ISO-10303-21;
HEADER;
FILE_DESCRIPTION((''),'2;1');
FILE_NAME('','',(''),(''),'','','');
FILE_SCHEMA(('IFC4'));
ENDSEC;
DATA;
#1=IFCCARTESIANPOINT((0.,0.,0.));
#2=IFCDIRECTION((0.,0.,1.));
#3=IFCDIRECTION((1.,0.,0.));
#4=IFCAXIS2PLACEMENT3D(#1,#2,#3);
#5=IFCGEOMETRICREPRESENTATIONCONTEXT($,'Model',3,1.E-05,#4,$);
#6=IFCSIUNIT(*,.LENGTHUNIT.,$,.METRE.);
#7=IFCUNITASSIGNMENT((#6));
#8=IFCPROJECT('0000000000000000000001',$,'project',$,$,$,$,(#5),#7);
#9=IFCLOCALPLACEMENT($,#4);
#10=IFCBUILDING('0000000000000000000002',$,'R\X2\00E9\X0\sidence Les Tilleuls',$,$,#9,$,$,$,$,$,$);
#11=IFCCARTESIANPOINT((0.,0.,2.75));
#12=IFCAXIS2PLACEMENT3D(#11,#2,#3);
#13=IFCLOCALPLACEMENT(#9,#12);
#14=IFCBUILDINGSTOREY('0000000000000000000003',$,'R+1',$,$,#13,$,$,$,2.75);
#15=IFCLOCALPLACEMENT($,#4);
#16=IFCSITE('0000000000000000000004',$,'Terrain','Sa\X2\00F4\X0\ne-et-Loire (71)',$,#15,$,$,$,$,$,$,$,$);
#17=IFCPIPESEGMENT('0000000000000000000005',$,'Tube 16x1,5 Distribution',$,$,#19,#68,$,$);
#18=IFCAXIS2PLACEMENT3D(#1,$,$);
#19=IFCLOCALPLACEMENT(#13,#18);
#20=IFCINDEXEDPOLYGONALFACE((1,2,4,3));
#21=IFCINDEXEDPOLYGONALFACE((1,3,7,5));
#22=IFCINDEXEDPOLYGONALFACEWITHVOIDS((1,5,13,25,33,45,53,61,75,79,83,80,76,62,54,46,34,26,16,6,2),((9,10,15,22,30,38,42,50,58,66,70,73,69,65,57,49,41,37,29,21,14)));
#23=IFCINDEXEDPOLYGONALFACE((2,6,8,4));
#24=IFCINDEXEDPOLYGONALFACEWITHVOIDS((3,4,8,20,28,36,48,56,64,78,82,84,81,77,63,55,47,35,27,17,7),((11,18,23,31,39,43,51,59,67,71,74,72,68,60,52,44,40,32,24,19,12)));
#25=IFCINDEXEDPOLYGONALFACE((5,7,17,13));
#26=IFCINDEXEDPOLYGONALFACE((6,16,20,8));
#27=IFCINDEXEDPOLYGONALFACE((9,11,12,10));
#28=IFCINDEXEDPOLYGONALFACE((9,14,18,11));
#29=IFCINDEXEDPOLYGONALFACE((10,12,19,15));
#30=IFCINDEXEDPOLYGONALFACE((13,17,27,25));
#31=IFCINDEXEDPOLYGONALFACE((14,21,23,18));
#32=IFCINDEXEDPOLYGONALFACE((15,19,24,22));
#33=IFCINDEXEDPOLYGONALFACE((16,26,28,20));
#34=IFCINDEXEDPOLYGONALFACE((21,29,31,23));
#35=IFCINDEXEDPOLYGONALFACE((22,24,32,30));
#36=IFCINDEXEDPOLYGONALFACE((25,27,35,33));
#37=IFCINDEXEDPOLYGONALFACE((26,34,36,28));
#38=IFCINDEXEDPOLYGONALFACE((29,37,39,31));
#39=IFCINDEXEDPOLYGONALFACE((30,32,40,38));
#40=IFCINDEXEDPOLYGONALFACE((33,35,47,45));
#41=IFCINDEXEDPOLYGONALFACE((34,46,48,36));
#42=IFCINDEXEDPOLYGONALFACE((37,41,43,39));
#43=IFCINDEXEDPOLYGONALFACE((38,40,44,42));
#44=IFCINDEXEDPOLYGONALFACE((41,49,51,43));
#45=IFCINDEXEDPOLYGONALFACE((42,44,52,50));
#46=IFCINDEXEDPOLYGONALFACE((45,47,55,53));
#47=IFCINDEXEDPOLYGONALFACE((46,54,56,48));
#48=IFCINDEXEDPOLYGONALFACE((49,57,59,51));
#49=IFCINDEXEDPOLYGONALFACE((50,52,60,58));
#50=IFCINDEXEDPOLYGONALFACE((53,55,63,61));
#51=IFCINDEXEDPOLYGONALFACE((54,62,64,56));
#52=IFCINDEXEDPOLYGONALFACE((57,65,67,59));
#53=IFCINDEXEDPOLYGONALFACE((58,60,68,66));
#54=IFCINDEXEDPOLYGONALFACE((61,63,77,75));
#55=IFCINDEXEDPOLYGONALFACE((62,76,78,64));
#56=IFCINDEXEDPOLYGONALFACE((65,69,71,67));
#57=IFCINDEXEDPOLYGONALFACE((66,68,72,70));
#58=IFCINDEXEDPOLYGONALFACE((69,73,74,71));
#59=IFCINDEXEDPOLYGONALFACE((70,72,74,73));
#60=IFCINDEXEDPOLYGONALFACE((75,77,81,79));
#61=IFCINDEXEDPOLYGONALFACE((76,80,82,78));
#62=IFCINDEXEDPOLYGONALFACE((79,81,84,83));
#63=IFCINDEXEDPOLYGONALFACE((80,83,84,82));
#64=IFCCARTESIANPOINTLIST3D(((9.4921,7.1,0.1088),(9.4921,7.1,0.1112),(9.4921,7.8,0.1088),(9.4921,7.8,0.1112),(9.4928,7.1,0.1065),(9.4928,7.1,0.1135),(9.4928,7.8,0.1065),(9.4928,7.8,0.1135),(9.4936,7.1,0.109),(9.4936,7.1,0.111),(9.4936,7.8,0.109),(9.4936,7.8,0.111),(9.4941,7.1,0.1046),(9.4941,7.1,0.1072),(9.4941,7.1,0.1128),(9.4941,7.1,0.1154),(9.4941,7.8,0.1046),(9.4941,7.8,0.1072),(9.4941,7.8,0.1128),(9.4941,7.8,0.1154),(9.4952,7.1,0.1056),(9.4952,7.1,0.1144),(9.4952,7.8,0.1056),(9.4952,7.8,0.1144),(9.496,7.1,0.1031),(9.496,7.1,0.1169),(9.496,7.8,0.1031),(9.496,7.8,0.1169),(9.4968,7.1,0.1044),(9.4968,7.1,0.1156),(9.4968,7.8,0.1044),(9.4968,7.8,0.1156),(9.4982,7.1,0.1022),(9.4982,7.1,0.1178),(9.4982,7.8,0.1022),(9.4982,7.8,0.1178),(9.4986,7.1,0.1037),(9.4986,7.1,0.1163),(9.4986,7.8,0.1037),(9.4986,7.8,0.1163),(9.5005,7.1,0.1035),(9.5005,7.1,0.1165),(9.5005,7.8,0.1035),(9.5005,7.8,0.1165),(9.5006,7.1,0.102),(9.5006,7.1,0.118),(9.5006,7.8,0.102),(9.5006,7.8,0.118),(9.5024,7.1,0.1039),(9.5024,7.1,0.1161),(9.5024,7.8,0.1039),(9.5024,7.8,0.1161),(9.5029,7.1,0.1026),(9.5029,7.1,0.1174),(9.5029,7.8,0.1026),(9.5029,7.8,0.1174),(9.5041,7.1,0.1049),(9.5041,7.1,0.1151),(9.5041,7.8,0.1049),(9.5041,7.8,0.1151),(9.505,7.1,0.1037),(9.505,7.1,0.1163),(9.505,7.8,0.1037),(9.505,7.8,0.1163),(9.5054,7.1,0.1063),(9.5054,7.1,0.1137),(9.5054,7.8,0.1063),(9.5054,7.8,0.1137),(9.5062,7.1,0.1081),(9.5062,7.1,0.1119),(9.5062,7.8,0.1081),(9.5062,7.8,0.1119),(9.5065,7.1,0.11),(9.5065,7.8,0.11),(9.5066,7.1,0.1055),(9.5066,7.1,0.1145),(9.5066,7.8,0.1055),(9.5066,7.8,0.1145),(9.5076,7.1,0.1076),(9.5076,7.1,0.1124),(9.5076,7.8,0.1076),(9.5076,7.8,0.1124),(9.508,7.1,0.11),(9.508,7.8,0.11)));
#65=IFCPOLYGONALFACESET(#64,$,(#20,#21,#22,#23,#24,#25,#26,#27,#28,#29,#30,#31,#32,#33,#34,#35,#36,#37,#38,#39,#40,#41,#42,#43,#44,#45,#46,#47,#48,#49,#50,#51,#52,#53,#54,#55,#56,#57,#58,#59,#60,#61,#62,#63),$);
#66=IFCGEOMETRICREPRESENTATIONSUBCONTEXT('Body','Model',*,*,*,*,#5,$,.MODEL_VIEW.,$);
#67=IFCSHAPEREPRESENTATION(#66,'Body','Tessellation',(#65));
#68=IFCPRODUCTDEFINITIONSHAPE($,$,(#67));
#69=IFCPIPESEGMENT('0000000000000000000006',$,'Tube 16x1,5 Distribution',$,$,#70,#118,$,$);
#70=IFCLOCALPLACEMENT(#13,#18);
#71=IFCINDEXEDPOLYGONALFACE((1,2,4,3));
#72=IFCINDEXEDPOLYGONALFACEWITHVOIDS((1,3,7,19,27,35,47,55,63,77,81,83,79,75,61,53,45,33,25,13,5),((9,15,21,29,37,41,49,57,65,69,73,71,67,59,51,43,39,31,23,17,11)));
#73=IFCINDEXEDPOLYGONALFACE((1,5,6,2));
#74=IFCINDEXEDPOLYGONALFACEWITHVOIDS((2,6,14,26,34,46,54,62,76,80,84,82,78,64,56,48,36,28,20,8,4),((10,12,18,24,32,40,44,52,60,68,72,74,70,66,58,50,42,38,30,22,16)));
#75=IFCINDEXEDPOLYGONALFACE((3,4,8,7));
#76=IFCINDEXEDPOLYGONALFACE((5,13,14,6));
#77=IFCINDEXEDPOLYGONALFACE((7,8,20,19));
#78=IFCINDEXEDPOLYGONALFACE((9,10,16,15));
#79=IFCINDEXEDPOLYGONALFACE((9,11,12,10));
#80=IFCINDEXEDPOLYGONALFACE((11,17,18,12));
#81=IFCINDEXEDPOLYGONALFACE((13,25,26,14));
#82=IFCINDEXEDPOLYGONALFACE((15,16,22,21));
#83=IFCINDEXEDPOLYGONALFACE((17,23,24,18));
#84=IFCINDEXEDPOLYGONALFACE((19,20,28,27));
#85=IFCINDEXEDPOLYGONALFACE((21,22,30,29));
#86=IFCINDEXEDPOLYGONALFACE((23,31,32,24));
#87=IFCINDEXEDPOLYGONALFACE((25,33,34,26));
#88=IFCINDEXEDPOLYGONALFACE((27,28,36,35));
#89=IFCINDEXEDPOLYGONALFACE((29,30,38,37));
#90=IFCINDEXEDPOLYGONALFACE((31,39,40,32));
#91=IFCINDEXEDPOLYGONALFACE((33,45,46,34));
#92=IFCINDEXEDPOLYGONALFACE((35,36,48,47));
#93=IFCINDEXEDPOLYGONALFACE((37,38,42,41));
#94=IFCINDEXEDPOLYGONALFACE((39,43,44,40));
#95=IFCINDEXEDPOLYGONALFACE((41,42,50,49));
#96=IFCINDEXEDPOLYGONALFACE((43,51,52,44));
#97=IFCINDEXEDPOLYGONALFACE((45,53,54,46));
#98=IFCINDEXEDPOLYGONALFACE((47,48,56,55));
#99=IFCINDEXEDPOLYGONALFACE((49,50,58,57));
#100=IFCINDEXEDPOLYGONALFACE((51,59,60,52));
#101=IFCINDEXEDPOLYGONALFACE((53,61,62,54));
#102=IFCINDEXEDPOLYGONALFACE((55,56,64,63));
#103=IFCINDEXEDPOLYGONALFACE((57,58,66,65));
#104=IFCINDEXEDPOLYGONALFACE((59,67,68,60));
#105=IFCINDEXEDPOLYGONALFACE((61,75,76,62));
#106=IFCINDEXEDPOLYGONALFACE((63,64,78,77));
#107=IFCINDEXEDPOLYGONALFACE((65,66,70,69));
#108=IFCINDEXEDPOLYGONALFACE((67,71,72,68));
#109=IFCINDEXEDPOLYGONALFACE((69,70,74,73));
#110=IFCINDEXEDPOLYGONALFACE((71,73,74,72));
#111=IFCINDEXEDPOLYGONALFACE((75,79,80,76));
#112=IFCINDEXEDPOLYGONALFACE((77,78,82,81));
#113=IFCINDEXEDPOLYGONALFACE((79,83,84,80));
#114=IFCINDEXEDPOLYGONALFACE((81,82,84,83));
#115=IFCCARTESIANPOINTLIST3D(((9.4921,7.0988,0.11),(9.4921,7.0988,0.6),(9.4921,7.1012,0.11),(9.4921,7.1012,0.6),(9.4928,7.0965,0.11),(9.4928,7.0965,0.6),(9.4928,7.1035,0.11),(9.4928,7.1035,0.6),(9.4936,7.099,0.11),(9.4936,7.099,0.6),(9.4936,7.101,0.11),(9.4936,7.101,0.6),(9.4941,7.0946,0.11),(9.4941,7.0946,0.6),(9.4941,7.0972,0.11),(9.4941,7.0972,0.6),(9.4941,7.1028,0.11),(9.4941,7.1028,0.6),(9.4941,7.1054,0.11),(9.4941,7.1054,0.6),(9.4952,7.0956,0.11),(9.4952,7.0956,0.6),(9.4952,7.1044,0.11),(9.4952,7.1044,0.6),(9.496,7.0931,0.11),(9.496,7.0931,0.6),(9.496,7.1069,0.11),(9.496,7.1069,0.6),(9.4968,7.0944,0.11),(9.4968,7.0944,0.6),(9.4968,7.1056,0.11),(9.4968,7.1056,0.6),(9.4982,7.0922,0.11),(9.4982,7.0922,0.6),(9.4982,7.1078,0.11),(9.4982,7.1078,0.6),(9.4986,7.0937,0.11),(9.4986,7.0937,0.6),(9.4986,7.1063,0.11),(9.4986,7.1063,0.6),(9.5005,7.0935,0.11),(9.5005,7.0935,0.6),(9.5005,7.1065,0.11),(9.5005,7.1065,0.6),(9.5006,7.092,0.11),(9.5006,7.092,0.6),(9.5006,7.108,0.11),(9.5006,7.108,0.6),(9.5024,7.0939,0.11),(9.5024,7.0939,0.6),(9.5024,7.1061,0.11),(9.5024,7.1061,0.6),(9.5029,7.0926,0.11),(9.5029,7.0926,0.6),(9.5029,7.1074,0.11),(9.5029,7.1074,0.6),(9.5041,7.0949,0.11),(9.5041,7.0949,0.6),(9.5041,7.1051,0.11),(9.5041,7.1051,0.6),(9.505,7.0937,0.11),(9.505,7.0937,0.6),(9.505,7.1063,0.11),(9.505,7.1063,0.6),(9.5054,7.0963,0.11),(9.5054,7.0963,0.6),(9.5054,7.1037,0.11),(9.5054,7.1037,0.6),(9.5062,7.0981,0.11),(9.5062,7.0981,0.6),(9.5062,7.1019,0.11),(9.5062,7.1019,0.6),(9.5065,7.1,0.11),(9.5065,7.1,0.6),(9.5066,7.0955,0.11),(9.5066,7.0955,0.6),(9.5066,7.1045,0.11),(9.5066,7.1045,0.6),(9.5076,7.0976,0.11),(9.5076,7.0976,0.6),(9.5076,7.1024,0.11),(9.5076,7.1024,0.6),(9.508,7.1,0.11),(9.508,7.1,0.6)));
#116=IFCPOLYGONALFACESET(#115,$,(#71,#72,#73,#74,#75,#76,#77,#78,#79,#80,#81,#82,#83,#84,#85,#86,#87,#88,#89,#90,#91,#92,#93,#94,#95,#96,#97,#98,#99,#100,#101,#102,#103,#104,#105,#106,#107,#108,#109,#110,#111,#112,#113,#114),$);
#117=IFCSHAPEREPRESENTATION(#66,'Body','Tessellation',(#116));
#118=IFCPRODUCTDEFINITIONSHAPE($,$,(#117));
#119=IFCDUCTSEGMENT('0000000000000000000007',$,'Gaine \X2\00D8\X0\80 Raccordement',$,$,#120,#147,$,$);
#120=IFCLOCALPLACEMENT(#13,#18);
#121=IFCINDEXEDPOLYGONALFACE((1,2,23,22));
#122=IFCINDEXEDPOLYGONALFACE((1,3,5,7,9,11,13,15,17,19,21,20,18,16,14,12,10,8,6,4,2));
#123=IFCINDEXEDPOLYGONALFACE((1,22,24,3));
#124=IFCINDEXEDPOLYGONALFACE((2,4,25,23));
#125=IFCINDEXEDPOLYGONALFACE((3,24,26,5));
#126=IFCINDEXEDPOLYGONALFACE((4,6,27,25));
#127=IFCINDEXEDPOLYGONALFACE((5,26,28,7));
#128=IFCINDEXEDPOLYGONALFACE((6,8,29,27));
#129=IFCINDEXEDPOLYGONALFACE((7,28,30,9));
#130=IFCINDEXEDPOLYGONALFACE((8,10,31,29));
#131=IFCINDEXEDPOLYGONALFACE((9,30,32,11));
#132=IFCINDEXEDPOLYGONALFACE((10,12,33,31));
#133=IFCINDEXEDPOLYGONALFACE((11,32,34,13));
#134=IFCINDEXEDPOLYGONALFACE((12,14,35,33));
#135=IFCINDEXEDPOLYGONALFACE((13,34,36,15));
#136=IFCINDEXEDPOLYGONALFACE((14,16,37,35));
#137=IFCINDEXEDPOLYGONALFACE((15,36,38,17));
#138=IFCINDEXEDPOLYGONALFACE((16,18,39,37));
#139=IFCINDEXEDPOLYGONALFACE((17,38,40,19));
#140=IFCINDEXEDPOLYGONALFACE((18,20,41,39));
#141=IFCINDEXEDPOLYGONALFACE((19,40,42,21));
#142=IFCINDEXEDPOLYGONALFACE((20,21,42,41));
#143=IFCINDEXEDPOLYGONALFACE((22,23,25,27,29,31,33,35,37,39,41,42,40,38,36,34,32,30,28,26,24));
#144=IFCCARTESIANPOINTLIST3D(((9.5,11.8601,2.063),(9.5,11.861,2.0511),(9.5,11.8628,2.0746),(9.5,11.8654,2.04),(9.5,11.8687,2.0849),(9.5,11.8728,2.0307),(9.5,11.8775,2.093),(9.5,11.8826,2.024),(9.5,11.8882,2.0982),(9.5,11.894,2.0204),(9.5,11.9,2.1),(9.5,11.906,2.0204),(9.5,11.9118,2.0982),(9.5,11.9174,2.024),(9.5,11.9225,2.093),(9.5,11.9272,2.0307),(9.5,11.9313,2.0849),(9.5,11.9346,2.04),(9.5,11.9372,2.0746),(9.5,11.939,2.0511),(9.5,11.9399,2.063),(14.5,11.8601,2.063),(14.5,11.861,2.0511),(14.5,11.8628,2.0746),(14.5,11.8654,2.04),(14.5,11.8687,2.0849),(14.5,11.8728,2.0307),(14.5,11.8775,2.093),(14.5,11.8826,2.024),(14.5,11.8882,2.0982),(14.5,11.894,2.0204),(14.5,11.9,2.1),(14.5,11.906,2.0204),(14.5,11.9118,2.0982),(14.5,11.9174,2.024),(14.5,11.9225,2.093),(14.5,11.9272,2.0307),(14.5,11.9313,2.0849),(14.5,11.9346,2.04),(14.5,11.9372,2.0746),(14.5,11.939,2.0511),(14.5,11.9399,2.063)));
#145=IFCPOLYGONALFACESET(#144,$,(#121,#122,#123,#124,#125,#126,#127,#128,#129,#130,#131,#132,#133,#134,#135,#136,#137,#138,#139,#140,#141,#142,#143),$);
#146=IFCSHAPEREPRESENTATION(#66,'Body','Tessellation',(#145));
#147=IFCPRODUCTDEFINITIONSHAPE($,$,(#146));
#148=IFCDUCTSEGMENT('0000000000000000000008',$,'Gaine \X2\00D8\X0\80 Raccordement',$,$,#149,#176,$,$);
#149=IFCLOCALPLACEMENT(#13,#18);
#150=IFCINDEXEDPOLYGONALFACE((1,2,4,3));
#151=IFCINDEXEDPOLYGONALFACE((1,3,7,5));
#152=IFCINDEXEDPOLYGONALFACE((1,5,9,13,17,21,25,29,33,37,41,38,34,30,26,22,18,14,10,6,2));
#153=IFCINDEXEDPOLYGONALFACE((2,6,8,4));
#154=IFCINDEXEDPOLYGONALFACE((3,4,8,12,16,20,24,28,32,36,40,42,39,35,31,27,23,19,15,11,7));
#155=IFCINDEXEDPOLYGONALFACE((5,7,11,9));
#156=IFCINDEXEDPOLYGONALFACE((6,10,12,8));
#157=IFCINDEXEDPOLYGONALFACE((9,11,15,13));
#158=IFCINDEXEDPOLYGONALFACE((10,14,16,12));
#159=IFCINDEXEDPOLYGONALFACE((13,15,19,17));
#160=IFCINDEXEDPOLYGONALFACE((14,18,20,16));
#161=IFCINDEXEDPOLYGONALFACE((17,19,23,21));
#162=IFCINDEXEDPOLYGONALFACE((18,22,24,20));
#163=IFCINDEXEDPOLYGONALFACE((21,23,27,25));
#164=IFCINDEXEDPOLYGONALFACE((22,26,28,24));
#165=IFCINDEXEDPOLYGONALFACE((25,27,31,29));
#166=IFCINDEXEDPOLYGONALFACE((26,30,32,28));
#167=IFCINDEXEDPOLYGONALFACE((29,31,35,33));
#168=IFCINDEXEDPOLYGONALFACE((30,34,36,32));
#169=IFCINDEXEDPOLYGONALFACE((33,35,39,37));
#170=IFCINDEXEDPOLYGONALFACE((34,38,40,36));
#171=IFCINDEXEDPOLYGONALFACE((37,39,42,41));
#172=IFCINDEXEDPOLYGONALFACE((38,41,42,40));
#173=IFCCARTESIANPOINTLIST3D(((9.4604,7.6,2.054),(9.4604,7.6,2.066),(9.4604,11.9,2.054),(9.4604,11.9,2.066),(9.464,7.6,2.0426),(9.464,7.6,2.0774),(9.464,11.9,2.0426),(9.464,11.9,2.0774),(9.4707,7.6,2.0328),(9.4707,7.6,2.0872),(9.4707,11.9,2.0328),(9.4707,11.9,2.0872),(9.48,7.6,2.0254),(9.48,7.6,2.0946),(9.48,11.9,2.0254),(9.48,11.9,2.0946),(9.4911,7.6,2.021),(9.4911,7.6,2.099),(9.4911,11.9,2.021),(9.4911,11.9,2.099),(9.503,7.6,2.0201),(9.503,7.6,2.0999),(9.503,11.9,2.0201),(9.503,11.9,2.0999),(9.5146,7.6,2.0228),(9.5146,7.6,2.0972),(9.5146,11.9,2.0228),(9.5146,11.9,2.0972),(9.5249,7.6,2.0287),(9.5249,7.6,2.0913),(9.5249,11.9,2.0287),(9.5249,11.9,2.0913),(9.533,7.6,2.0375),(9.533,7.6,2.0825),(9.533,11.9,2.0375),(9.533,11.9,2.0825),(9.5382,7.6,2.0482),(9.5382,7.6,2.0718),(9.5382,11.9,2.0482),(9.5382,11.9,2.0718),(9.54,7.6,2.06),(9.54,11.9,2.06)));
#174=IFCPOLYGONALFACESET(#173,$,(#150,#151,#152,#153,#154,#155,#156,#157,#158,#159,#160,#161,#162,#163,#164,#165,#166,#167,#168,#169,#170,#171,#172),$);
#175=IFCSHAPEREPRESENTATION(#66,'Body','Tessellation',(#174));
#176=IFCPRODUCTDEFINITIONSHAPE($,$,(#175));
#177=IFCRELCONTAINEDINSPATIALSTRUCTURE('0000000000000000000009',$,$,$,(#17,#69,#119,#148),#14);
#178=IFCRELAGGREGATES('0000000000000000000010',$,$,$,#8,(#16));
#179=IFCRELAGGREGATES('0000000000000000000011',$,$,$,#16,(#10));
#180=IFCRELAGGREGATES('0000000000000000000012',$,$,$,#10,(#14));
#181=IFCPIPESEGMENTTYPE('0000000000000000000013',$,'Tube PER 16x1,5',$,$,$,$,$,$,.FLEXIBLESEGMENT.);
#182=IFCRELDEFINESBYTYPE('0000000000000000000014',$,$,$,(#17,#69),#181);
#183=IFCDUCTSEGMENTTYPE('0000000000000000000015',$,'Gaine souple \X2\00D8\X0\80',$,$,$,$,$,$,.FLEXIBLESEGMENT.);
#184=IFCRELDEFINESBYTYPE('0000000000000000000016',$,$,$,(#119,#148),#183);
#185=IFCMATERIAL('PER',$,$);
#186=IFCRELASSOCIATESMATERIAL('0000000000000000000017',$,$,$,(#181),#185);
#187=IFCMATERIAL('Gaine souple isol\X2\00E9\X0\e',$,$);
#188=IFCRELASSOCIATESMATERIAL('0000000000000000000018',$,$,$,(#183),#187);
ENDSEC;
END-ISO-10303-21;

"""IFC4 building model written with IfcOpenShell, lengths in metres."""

from ifc_helpers import new_model, si_unit, frame, origin_with_axes, place, context, subcontext, project, spatial, circle, hollow_circle, extrude, material, type_object, element, save


model = new_model("IFC4")

# Units and contexts
model_context = context("Model", 3, precision=1e-05, world=origin_with_axes())
body_context = subcontext(model_context, "Body", "Model", "MODEL_VIEW")
ifc_project = project(units=[si_unit("LENGTHUNIT", "METRE")], contexts=[model_context])

# Site, building, storey
site_placement = place(None, origin_with_axes())
site = spatial("IfcSite", under=ifc_project, at=site_placement, Name="Terrain", Description="Saône-et-Loire (71)")
building_placement = place(None, origin_with_axes())
building = spatial("IfcBuilding", under=site, at=building_placement, Name="Résidence Les Tilleuls")
storey_placement = place(building_placement, frame((0.0, 0.0, 2.75), z_axis=(0.0, 0.0, 1.0), x_axis=(1.0, 0.0, 0.0)))
storey = spatial("IfcBuildingStorey", under=building, at=storey_placement, Name="R+1", Elevation=2.75)

# Pipe segments
ifc_material_1 = material(Name="PER")
pipe_segment_type_1 = type_object("IfcPipeSegmentType", Name="Tube PER 16x1,5", PredefinedType="FLEXIBLESEGMENT", material=ifc_material_1)
pipe_segment_1_placement = place(storey_placement, frame((9.5, 7.8, 0.11), z_axis=(0.0, -1.0, 0.0), x_axis=(1.0, 0.0, 0.0)))
element("IfcPipeSegment", 1, at=pipe_segment_1_placement, inside=storey, type_object=pipe_segment_type_1, Name="Tube 16x1,5 Distribution", context=body_context, shape_type="SweptSolid", body=[
    extrude(hollow_circle(Radius=0.008, WallThickness=0.0015), origin_with_axes(), (0.0, 0.0, 1.0), 0.7),
])
pipe_segment_2_placement = place(storey_placement, frame((9.5, 7.1, 0.11), z_axis=(0.0, 0.0, 1.0), x_axis=(1.0, 0.0, 0.0)))
element("IfcPipeSegment", 2, at=pipe_segment_2_placement, inside=storey, type_object=pipe_segment_type_1, Name="Tube 16x1,5 Distribution", context=body_context, shape_type="SweptSolid", body=[
    extrude(hollow_circle(Radius=0.008, WallThickness=0.0015), origin_with_axes(), (0.0, 0.0, 1.0), 0.49),
])

# Duct segments
ifc_material_2 = material(Name="Gaine souple isolée")
duct_segment_type = type_object("IfcDuctSegmentType", Name="Gaine souple Ø80", PredefinedType="FLEXIBLESEGMENT", material=ifc_material_2)
duct_segment_1_placement = place(storey_placement, frame((9.5, 11.9, 2.06), z_axis=(1.0, 0.0, 0.0), x_axis=(0.0, 0.0, 1.0)))
element("IfcDuctSegment", 3, at=duct_segment_1_placement, inside=storey, type_object=duct_segment_type, Name="Gaine Ø80 Raccordement", context=body_context, shape_type="SweptSolid", body=[
    extrude(circle(Radius=0.04), origin_with_axes(), (0.0, 0.0, 1.0), 5.0),
])
duct_segment_2_placement = place(storey_placement, frame((9.5, 7.6, 2.06), z_axis=(0.0, 1.0, 0.0), x_axis=(1.0, 0.0, 0.0)))
element("IfcDuctSegment", 4, at=duct_segment_2_placement, inside=storey, type_object=duct_segment_type, Name="Gaine Ø80 Raccordement", context=body_context, shape_type="SweptSolid", body=[
    extrude(circle(Radius=0.04), origin_with_axes(), (0.0, 0.0, 1.0), 4.3),
])

save(model, "model.ifc")
